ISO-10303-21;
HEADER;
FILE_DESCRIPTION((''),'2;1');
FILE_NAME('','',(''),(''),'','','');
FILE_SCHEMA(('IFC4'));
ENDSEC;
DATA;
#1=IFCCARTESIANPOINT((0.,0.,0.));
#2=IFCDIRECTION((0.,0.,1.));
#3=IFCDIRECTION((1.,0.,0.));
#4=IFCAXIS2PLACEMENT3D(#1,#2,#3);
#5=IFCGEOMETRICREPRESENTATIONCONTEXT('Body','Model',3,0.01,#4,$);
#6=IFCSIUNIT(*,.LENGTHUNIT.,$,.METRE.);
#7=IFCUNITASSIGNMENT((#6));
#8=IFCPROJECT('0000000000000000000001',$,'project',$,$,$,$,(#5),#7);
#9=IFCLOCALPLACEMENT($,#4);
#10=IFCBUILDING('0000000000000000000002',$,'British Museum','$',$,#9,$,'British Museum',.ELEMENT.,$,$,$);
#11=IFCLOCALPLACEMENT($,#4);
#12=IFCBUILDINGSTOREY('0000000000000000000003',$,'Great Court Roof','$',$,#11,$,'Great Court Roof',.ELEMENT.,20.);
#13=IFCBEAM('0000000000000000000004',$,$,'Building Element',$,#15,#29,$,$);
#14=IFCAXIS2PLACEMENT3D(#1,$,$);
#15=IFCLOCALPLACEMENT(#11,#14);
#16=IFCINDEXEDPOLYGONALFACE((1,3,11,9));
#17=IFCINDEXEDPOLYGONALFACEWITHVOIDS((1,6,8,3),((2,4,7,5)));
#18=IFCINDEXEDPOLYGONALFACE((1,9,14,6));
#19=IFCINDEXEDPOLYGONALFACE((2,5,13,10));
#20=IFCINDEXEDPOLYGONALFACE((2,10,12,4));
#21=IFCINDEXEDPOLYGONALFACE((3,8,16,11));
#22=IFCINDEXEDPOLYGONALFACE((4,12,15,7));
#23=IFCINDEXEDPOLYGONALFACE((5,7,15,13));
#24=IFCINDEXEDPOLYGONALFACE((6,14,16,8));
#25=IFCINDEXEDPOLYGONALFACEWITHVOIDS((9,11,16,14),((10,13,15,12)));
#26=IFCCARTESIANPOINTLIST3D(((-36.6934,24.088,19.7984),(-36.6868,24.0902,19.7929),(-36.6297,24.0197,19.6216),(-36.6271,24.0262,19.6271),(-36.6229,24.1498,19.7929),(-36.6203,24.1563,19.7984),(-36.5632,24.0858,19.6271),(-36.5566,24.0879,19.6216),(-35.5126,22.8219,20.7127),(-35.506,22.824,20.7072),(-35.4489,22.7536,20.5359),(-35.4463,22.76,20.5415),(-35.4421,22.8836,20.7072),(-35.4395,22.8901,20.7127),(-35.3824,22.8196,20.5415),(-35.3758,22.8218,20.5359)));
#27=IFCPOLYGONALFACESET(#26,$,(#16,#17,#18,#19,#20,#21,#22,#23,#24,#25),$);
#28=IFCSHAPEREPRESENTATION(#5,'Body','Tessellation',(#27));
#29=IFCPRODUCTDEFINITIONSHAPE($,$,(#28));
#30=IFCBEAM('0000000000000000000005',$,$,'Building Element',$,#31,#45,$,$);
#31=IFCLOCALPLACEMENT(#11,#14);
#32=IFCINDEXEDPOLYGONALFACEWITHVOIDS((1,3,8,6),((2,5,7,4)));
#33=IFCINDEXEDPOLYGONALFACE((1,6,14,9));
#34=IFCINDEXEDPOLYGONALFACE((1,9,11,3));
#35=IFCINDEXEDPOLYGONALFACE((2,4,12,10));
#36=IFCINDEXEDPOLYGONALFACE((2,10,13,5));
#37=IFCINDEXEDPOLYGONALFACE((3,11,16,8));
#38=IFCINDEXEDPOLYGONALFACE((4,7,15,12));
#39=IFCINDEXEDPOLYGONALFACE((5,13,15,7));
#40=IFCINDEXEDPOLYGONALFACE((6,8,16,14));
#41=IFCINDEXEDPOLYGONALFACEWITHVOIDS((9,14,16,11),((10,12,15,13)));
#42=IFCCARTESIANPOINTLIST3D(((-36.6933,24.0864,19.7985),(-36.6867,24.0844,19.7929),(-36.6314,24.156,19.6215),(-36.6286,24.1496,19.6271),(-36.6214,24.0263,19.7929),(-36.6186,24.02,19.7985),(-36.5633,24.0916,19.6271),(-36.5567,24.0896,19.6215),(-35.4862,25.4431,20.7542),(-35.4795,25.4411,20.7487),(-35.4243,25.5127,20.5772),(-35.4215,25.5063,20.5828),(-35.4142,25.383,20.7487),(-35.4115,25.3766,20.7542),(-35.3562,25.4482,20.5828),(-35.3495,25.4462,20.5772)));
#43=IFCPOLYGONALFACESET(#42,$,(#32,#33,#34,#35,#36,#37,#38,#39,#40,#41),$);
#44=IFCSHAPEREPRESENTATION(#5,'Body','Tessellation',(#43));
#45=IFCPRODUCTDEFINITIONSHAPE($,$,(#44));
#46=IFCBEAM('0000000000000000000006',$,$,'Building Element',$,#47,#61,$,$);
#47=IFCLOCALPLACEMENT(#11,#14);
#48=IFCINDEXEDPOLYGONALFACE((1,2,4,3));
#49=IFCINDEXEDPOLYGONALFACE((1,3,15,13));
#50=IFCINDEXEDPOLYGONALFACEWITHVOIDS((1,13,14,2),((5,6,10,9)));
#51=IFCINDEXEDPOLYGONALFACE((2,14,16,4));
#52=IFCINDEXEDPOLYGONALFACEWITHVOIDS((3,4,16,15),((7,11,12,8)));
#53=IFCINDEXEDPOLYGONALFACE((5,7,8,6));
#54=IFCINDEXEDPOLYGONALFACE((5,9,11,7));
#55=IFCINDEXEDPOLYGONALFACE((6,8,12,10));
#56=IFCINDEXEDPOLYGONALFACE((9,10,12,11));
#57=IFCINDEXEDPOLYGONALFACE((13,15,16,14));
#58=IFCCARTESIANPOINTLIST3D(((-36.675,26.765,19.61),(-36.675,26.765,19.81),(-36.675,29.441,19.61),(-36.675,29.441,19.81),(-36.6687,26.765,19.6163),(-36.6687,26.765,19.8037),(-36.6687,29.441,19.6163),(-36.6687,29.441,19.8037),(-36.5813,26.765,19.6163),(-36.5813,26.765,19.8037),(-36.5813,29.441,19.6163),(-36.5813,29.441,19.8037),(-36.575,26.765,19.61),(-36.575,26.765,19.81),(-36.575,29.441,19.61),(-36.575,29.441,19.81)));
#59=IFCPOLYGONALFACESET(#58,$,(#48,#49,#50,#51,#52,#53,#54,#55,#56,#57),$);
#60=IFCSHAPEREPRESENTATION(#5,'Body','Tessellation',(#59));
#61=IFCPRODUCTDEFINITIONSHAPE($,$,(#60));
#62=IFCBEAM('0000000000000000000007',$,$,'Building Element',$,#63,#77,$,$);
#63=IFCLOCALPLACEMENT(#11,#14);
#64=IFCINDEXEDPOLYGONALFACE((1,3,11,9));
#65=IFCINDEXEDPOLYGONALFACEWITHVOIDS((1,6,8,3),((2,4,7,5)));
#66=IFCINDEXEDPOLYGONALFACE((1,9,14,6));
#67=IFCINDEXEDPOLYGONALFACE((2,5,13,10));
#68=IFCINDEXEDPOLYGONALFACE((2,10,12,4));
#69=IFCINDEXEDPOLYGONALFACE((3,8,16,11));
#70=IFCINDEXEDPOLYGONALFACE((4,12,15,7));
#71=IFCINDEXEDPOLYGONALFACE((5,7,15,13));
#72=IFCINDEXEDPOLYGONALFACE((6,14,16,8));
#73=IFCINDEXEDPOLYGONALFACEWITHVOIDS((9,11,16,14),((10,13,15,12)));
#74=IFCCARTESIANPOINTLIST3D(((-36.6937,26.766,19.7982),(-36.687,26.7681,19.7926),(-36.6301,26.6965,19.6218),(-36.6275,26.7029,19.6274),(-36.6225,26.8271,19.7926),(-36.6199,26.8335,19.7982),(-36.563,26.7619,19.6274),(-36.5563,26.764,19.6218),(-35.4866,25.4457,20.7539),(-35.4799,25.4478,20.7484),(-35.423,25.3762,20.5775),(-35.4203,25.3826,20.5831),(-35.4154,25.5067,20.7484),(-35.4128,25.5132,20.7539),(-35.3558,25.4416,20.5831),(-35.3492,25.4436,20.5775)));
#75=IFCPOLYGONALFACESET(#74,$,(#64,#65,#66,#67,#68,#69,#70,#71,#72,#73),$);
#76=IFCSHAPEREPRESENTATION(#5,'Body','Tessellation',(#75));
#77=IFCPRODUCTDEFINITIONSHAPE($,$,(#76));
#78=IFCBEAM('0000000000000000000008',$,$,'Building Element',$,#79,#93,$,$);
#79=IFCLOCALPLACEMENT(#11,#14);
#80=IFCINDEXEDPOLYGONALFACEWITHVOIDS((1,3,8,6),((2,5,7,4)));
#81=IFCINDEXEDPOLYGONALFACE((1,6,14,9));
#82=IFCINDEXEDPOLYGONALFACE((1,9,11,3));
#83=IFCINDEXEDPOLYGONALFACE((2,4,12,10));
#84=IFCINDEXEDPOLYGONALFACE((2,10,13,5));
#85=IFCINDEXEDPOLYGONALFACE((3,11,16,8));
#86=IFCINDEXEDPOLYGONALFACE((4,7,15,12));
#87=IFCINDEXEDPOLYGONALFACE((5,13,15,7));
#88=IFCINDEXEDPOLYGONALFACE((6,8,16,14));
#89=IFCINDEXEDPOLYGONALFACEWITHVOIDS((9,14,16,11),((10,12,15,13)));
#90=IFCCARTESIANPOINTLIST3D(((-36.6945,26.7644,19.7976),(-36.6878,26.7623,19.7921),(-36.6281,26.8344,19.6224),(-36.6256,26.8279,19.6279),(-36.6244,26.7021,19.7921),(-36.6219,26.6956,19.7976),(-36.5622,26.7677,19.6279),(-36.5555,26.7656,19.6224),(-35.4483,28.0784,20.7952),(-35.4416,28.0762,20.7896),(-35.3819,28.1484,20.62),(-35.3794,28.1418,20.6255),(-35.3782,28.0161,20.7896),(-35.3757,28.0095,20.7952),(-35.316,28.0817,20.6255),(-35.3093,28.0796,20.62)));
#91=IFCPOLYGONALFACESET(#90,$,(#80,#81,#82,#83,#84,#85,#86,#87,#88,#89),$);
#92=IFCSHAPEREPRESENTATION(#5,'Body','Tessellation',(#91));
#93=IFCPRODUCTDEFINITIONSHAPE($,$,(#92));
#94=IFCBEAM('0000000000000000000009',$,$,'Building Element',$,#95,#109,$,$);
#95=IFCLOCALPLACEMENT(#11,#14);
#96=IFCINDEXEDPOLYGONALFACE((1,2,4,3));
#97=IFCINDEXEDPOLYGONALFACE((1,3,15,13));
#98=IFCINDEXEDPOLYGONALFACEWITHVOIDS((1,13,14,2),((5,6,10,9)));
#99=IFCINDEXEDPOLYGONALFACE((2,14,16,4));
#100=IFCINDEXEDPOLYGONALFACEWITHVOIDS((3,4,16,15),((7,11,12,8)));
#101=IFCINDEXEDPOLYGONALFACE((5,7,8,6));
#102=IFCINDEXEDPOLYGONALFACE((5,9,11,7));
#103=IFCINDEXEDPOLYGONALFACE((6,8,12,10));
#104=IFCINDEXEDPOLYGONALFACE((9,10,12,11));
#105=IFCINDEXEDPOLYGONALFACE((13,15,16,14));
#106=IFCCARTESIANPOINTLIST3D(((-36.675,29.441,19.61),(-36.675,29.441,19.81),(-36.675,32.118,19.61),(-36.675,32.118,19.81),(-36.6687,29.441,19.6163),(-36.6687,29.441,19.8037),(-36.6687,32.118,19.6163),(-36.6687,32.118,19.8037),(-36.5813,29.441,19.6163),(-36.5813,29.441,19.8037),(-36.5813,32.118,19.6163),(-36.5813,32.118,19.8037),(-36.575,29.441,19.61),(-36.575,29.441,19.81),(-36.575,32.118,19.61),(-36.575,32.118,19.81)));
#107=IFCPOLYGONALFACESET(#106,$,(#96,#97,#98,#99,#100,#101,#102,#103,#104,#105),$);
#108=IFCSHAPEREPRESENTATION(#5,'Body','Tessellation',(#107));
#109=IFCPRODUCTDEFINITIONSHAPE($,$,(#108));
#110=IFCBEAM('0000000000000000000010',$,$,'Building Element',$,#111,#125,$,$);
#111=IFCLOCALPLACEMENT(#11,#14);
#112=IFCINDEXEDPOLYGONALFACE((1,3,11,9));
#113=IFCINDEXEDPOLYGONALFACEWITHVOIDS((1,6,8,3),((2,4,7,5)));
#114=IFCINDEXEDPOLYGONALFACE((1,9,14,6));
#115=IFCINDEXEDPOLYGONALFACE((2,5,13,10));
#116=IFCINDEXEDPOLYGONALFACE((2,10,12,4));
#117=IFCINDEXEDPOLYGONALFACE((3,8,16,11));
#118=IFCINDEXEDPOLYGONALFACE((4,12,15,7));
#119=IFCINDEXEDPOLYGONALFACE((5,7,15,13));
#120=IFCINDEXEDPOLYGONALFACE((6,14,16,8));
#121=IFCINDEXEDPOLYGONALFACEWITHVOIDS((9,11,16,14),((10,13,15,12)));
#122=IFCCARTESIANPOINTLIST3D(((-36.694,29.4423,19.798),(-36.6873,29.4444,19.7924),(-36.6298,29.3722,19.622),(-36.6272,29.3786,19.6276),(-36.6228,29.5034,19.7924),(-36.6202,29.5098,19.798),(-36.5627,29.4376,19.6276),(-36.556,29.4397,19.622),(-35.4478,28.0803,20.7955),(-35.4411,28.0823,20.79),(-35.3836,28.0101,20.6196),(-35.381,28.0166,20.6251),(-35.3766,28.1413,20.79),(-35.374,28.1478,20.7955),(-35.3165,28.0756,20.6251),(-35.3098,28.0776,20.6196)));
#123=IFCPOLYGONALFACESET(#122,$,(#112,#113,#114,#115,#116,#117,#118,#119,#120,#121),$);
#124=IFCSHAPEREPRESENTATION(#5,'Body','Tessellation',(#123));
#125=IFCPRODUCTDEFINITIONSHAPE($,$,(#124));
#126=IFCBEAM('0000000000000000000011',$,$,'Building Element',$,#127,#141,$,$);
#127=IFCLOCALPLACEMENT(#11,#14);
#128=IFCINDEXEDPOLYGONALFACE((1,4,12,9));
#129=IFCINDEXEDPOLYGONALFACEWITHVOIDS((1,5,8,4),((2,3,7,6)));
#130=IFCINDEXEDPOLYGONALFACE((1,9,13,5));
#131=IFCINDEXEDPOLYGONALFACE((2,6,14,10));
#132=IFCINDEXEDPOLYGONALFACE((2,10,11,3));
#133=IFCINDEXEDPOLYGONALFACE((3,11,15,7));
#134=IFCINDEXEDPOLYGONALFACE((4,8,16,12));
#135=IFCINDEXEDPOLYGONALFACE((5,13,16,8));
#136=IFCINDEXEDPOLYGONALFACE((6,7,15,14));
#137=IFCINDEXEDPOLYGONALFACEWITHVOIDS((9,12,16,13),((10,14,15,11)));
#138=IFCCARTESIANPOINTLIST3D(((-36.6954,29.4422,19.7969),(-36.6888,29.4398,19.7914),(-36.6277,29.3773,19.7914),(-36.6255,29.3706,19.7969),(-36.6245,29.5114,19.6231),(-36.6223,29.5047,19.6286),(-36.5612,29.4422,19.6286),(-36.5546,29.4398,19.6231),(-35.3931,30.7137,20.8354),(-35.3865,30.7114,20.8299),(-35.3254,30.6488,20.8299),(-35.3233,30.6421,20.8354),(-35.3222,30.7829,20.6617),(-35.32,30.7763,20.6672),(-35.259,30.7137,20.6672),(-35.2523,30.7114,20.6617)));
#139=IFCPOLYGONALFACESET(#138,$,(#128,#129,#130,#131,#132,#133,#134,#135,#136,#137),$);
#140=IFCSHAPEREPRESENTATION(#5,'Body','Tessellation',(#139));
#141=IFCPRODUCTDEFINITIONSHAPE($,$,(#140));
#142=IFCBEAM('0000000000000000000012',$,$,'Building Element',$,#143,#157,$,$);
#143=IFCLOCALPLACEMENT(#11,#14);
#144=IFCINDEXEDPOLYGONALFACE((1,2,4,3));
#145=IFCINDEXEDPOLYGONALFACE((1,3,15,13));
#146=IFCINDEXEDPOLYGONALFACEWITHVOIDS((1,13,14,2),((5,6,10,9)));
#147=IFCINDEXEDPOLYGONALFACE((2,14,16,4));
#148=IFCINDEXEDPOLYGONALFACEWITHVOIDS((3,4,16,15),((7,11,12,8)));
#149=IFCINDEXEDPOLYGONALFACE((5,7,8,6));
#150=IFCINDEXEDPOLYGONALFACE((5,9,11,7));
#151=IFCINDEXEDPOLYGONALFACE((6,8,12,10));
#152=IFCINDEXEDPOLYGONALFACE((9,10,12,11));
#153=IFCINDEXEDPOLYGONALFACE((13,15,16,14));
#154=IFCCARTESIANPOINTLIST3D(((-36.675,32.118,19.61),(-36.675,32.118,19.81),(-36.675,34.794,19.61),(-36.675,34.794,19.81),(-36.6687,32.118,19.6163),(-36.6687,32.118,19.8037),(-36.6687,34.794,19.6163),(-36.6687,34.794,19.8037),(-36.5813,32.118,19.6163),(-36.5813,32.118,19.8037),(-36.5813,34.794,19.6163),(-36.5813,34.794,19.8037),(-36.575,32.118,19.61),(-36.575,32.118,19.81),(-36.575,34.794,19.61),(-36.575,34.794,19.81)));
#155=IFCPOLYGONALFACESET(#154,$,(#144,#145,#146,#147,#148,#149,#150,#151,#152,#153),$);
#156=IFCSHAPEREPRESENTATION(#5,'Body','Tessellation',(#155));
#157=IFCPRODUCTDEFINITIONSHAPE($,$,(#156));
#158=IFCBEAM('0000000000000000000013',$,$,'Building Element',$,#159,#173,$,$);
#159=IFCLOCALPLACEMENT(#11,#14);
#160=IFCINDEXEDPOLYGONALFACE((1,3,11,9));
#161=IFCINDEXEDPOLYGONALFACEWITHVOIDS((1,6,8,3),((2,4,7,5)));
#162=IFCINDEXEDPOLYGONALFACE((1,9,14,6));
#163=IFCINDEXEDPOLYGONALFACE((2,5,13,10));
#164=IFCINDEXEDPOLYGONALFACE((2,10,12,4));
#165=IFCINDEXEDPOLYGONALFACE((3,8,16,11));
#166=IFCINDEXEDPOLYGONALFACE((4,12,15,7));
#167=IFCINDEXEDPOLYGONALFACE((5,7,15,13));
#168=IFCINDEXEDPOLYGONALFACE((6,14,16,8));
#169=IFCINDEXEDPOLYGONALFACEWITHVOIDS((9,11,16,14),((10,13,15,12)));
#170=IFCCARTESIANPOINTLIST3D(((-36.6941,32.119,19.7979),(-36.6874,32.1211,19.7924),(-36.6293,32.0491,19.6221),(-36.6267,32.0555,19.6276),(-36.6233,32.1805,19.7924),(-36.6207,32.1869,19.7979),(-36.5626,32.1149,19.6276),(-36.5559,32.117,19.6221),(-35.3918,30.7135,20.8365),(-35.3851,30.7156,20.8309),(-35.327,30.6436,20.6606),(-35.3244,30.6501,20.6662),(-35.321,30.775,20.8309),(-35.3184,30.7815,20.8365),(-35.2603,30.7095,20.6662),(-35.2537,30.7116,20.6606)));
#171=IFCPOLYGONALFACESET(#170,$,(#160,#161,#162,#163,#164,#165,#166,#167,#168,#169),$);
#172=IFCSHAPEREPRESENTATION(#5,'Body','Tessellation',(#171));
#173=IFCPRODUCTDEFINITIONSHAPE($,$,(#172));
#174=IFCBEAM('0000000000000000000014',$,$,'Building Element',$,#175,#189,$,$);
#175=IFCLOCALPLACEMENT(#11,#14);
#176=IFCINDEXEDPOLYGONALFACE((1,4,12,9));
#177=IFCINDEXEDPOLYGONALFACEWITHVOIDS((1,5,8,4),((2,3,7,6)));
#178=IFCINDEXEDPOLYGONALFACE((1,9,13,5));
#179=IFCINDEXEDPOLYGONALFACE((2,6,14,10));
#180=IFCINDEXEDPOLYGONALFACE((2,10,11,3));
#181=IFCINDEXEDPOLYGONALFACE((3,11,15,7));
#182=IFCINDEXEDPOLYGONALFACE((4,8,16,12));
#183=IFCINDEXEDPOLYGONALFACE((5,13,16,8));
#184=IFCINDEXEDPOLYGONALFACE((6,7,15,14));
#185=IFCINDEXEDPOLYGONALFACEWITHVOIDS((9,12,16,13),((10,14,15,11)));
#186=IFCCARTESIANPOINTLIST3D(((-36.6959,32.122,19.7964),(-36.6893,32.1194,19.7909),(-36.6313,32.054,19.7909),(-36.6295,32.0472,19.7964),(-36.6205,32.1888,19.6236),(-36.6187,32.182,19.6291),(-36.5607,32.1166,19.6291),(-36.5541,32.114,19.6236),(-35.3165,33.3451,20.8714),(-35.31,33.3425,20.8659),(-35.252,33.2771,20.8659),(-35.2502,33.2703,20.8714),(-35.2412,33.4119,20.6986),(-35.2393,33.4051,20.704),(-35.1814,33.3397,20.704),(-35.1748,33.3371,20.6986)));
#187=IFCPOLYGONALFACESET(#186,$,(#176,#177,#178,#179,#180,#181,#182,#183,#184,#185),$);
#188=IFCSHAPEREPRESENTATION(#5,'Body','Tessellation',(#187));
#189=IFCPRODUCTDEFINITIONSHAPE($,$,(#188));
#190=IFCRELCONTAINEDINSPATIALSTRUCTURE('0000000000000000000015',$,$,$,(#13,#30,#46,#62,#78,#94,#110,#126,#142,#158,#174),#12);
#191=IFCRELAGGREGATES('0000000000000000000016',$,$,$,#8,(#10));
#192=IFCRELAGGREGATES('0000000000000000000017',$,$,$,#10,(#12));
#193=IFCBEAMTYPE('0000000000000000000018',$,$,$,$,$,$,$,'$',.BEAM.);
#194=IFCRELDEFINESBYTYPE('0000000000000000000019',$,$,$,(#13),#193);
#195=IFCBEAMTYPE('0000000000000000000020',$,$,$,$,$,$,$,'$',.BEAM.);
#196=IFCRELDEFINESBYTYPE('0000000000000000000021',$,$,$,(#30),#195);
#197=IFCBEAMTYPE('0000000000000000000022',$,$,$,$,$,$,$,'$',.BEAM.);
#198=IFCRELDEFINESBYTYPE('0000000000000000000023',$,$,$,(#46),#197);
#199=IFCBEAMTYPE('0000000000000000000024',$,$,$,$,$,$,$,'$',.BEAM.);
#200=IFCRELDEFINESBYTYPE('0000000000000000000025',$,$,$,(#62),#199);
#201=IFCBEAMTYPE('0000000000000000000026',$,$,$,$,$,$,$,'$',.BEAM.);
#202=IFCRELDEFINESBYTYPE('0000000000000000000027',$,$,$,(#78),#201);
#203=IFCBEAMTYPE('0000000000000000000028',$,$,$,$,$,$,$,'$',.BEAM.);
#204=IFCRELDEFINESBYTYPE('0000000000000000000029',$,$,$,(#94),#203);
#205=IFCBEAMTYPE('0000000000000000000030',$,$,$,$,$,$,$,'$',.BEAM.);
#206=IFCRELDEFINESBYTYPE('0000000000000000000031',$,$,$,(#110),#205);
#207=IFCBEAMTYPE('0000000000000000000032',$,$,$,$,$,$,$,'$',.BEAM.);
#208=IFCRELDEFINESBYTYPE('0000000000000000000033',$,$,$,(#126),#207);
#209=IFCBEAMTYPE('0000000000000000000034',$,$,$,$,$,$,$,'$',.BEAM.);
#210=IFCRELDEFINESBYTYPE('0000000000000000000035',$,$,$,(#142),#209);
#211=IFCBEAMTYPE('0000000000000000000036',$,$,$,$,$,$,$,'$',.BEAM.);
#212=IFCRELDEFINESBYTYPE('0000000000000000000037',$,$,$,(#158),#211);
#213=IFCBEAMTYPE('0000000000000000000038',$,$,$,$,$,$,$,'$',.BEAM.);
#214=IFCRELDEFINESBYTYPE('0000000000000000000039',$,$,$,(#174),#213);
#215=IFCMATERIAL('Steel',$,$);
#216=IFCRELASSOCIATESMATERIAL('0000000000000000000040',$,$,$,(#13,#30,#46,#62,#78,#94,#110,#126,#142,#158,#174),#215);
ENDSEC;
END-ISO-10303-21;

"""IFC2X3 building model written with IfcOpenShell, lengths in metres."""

from ifc_helpers import new_model, si_unit, frame, origin_with_axes, origin_2d, place, context, project, spatial, hollow_rectangle, extrude, material, type_object, element, save


model = new_model("IFC2X3")

# Units and contexts
model_context = context("Model", 3, precision=0.01, world=origin_with_axes(), identifier="Body")
ifc_project = project(units=[si_unit("LENGTHUNIT", "METRE")], contexts=[model_context])

# Building, storey
building_placement = place(None, origin_with_axes())
building = spatial("IfcBuilding", under=ifc_project, at=building_placement, Name="British Museum", Description="$", LongName="British Museum", CompositionType="ELEMENT")
storey_placement = place(None, origin_with_axes())
storey = spatial("IfcBuildingStorey", under=building, at=storey_placement, Name="Great Court Roof", Description="$", LongName="Great Court Roof", CompositionType="ELEMENT", Elevation=20.0)

# Beams
ifc_material = material(Name="Steel")
beam_type_1 = type_object("IfcBeamType", ElementType="$", PredefinedType="BEAM")
beam_1_placement = place(None, origin_with_axes())
element("IfcBeam", 1, at=beam_1_placement, inside=storey, type_object=beam_type_1, material=ifc_material, Description="Building Element", context=model_context, shape_type="SweptSolid", body=[
    extrude(hollow_rectangle(XDim=0.1, YDim=0.2, WallThickness=0.0063, InnerFilletRadius=-0.0063, OuterFilletRadius=0.0, at=origin_2d()), frame((-36.625, 24.088, 19.71), z_axis=(0.603089, -0.646694, 0.466981), x_axis=(0.731333, 0.682021, 0.0)), (0.0, 0.0, 1.0), 1.9579),
])
beam_type_2 = type_object("IfcBeamType", ElementType="$", PredefinedType="BEAM")
beam_2_placement = place(None, origin_with_axes())
element("IfcBeam", 2, at=beam_2_placement, inside=storey, type_object=beam_type_2, material=ifc_material, Description="Building Element", context=model_context, shape_type="SweptSolid", body=[
    extrude(hollow_rectangle(XDim=0.1, YDim=0.2, WallThickness=0.0063, InnerFilletRadius=-0.0063, OuterFilletRadius=0.0, at=origin_2d()), frame((-36.625, 24.088, 19.71), z_axis=(0.588242, 0.661109, 0.465732), x_axis=(-0.747079, 0.664735, 0.0)), (0.0, 0.0, 1.0), 2.0521),
])
beam_type_3 = type_object("IfcBeamType", ElementType="$", PredefinedType="BEAM")
beam_3_placement = place(None, origin_with_axes())
element("IfcBeam", 3, at=beam_3_placement, inside=storey, type_object=beam_type_3, material=ifc_material, Description="Building Element", context=model_context, shape_type="SweptSolid", body=[
    extrude(hollow_rectangle(XDim=0.1, YDim=0.2, WallThickness=0.0063, InnerFilletRadius=-0.0063, OuterFilletRadius=0.0, at=origin_2d()), frame((-36.625, 26.765, 19.71), z_axis=(0.0, 1.0, 0.0), x_axis=(-1.0, 0.0, 0.0)), (0.0, 0.0, 1.0), 2.676),
])
beam_type_4 = type_object("IfcBeamType", ElementType="$", PredefinedType="BEAM")
beam_4_placement = place(None, origin_with_axes())
element("IfcBeam", 4, at=beam_4_placement, inside=storey, type_object=beam_type_4, material=ifc_material, Description="Building Element", context=model_context, shape_type="SweptSolid", body=[
    extrude(hollow_rectangle(XDim=0.1, YDim=0.2, WallThickness=0.0063, InnerFilletRadius=-0.0063, OuterFilletRadius=0.0, at=origin_2d()), frame((-36.625, 26.765, 19.71), z_axis=(0.595157, -0.650963, 0.471207), x_axis=(0.738034, 0.674763, 0.0)), (0.0, 0.0, 1.0), 2.0283),
])
beam_type_5 = type_object("IfcBeamType", ElementType="$", PredefinedType="BEAM")
beam_5_placement = place(None, origin_with_axes())
element("IfcBeam", 5, at=beam_5_placement, inside=storey, type_object=beam_type_5, material=ifc_material, Description="Building Element", context=model_context, shape_type="SweptSolid", body=[
    extrude(hollow_rectangle(XDim=0.1, YDim=0.2, WallThickness=0.0063, InnerFilletRadius=-0.0063, OuterFilletRadius=0.0, at=origin_2d()), frame((-36.625, 26.765, 19.71), z_axis=(0.602751, 0.635523, 0.482495), x_axis=(-0.725567, 0.688152, 0.0)), (0.0, 0.0, 1.0), 2.0675),
])
beam_type_6 = type_object("IfcBeamType", ElementType="$", PredefinedType="BEAM")
beam_6_placement = place(None, origin_with_axes())
element("IfcBeam", 6, at=beam_6_placement, inside=storey, type_object=beam_type_6, material=ifc_material, Description="Building Element", context=model_context, shape_type="SweptSolid", body=[
    extrude(hollow_rectangle(XDim=0.1, YDim=0.2, WallThickness=0.0063, InnerFilletRadius=-0.0063, OuterFilletRadius=0.0, at=origin_2d()), frame((-36.625, 29.441, 19.71), z_axis=(0.0, 1.0, 0.0), x_axis=(-1.0, 0.0, 0.0)), (0.0, 0.0, 1.0), 2.677),
])
beam_type_7 = type_object("IfcBeamType", ElementType="$", PredefinedType="BEAM")
beam_7_placement = place(None, origin_with_axes())
element("IfcBeam", 7, at=beam_7_placement, inside=storey, type_object=beam_type_7, material=ifc_material, Description="Building Element", context=model_context, shape_type="SweptSolid", body=[
    extrude(hollow_rectangle(XDim=0.1, YDim=0.2, WallThickness=0.0063, InnerFilletRadius=-0.0063, OuterFilletRadius=0.0, at=origin_2d()), frame((-36.625, 29.441, 19.71), z_axis=(0.59388, -0.649082, 0.475394), x_axis=(0.737783, 0.675038, 0.0)), (0.0, 0.0, 1.0), 2.0984),
])
beam_type_8 = type_object("IfcBeamType", ElementType="$", PredefinedType="BEAM")
beam_8_placement = place(None, origin_with_axes())
element("IfcBeam", 8, at=beam_8_placement, inside=storey, type_object=beam_type_8, material=ifc_material, Description="Building Element", context=model_context, shape_type="SweptSolid", body=[
    extrude(hollow_rectangle(XDim=0.1, YDim=0.2, WallThickness=0.0063, InnerFilletRadius=-0.0063, OuterFilletRadius=0.0, at=origin_2d()), frame((-36.625, 29.441, 19.71), z_axis=(0.621445, 0.606784, 0.4956), x_axis=(-0.698617, 0.715496, 0.0)), (0.0, 0.0, 1.0), 2.0956),
])
beam_type_9 = type_object("IfcBeamType", ElementType="$", PredefinedType="BEAM")
beam_9_placement = place(None, origin_with_axes())
element("IfcBeam", 9, at=beam_9_placement, inside=storey, type_object=beam_type_9, material=ifc_material, Description="Building Element", context=model_context, shape_type="SweptSolid", body=[
    extrude(hollow_rectangle(XDim=0.1, YDim=0.2, WallThickness=0.0063, InnerFilletRadius=-0.0063, OuterFilletRadius=0.0, at=origin_2d()), frame((-36.625, 32.118, 19.71), z_axis=(0.0, 1.0, 0.0), x_axis=(-1.0, 0.0, 0.0)), (0.0, 0.0, 1.0), 2.676),
])
beam_type_10 = type_object("IfcBeamType", ElementType="$", PredefinedType="BEAM")
beam_10_placement = place(None, origin_with_axes())
element("IfcBeam", 10, at=beam_10_placement, inside=storey, type_object=beam_type_10, material=ifc_material, Description="Building Element", context=model_context, shape_type="SweptSolid", body=[
    extrude(hollow_rectangle(XDim=0.1, YDim=0.2, WallThickness=0.0063, InnerFilletRadius=-0.0063, OuterFilletRadius=0.0, at=origin_2d()), frame((-36.625, 32.118, 19.71), z_axis=(0.597535, -0.64488, 0.476532), x_axis=(0.73352, 0.679668, 0.0)), (0.0, 0.0, 1.0), 2.1794),
])
beam_type_11 = type_object("IfcBeamType", ElementType="$", PredefinedType="BEAM")
beam_11_placement = place(None, origin_with_axes())
element("IfcBeam", 11, at=beam_11_placement, inside=storey, type_object=beam_type_11, material=ifc_material, Description="Building Element", context=model_context, shape_type="SweptSolid", body=[
    extrude(hollow_rectangle(XDim=0.1, YDim=0.2, WallThickness=0.0063, InnerFilletRadius=-0.0063, OuterFilletRadius=0.0, at=origin_2d()), frame((-36.625, 32.118, 19.71), z_axis=(0.646349, 0.573142, 0.503728), x_axis=(-0.663464, 0.748208, 0.0)), (0.0, 0.0, 1.0), 2.134),
])

save(model, "model.ifc")
